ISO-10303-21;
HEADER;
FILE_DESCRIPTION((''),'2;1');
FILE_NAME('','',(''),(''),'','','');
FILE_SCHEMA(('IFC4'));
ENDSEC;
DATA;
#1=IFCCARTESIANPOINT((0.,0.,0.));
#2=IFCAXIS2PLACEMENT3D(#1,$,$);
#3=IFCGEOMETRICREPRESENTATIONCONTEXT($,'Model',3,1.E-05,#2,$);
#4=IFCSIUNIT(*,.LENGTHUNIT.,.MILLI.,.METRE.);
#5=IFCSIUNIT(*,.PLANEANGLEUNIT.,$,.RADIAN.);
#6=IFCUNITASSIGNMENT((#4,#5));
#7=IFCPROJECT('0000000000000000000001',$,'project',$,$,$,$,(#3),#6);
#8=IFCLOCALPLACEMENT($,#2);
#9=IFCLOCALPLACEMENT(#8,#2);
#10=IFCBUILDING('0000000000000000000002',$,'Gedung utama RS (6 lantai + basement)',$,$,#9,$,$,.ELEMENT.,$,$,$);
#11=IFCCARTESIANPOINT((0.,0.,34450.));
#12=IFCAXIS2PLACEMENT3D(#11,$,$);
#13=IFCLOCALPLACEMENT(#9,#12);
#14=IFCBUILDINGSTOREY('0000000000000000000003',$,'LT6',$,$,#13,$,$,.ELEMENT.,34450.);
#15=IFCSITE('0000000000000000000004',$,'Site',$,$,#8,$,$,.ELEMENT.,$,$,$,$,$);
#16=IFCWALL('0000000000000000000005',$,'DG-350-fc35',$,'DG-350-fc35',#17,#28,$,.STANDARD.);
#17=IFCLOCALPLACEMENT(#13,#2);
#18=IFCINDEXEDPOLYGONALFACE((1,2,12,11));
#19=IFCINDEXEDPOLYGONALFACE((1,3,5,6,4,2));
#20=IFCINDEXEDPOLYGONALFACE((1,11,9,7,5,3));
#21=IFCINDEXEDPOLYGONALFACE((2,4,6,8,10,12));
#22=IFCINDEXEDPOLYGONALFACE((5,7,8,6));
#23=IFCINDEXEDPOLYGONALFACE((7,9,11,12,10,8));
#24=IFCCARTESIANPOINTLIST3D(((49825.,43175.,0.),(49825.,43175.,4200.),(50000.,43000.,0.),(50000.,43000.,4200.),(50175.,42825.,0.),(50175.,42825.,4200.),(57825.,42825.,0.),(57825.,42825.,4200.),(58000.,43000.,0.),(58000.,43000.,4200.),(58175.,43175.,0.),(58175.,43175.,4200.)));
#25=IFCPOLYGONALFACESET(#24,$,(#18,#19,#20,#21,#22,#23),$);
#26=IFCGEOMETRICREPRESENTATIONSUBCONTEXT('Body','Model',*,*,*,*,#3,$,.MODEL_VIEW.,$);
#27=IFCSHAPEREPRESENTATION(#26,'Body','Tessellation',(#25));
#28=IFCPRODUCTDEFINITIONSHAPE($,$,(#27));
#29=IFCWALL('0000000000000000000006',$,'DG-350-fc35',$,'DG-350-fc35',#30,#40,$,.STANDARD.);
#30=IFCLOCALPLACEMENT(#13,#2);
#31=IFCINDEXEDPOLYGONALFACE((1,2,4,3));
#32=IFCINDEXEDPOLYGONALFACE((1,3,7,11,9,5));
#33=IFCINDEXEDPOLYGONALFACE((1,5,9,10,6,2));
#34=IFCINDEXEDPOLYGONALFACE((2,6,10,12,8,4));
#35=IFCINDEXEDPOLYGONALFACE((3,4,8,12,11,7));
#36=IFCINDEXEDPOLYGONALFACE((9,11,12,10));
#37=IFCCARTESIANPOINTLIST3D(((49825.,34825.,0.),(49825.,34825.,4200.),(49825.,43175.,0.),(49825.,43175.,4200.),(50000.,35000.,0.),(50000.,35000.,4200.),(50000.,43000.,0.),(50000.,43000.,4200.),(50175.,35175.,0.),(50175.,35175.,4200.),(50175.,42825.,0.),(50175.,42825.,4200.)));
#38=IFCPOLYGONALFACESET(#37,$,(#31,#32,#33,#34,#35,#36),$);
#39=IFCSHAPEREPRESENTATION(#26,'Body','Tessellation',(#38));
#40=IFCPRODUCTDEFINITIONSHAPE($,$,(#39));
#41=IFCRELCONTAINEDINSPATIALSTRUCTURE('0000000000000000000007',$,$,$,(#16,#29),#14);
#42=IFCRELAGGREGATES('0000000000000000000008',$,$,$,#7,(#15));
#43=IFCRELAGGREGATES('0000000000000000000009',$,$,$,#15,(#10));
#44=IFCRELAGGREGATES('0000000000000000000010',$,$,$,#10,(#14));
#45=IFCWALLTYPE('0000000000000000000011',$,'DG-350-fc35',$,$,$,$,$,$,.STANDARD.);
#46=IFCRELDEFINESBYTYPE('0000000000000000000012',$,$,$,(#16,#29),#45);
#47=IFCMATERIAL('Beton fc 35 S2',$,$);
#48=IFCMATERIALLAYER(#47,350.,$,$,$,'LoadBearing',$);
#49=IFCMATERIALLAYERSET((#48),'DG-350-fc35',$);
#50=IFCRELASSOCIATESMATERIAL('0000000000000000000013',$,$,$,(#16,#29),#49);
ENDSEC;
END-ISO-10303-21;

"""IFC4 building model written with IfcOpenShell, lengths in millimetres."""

from ifc_helpers import new_model, si_unit, frame, origin, place, context, subcontext, project, spatial, polyline, outline, extrude, material, layer, layer_set, layer_usage, type_object, element, save


model = new_model("IFC4")

# Units and contexts
model_context = context("Model", 3, precision=1e-05, world=origin())
body_context = subcontext(model_context, "Body", "Model", "MODEL_VIEW")
ifc_project = project(units=[si_unit("LENGTHUNIT", "METRE", prefix="MILLI"), si_unit("PLANEANGLEUNIT", "RADIAN")], contexts=[model_context])

# Site, building, storey
site_placement = place(None, origin())
site = spatial("IfcSite", under=ifc_project, at=site_placement, Name="Site", CompositionType="ELEMENT")
building_placement = place(site_placement, origin())
building = spatial("IfcBuilding", under=site, at=building_placement, Name="Gedung utama RS (6 lantai + basement)", CompositionType="ELEMENT")
storey_placement = place(building_placement, frame((0.0, 0.0, 34450.0)))
storey = spatial("IfcBuildingStorey", under=building, at=storey_placement, Name="LT6", CompositionType="ELEMENT", Elevation=34450.0)

# Shared definitions
ifc_material_1 = material(Name="Beton fc 35 S2")
ifc_layer = layer(ifc_material_1, 350.0, Category="LoadBearing")
ifc_layer_set = layer_set([ifc_layer], Name="DG-350-fc35")
ifc_layer_usage = layer_usage(ifc_layer_set, "AXIS2", "NEGATIVE", 175.0)
wall_type = type_object("IfcWallType", Name="DG-350-fc35", PredefinedType="STANDARD")

# Walls
for number, where, z_axis, x_axis, name in (
    (1, (58000.0, 43000.0, 0.0), (0.0, 0.0, 1.0), (-1.0, 0.0, 0.0), "DG-350-fc35"),
    (2, (50000.0, 43000.0, 0.0), (0.0, 0.0, 1.0), (0.0, -1.0, 0.0), "DG-350-fc35"),
):
    element("IfcWall", number, at=place(storey_placement, frame(where, z_axis=z_axis, x_axis=x_axis)), inside=storey, type_object=wall_type, material=ifc_layer_usage, Name=name, ObjectType="DG-350-fc35", PredefinedType="STANDARD", context=body_context, shape_type="SweptSolid", body=[
        extrude(outline(polyline([(-175.0, -175.0), (0.0, 0.0), (175.0, 175.0), (7825.0, 175.0), (8000.0, 0.0), (8175.0, -175.0), (-175.0, -175.0)])), origin(), (0.0, 0.0, 1.0), 4200.0),
    ])

save(model, "model.ifc")
